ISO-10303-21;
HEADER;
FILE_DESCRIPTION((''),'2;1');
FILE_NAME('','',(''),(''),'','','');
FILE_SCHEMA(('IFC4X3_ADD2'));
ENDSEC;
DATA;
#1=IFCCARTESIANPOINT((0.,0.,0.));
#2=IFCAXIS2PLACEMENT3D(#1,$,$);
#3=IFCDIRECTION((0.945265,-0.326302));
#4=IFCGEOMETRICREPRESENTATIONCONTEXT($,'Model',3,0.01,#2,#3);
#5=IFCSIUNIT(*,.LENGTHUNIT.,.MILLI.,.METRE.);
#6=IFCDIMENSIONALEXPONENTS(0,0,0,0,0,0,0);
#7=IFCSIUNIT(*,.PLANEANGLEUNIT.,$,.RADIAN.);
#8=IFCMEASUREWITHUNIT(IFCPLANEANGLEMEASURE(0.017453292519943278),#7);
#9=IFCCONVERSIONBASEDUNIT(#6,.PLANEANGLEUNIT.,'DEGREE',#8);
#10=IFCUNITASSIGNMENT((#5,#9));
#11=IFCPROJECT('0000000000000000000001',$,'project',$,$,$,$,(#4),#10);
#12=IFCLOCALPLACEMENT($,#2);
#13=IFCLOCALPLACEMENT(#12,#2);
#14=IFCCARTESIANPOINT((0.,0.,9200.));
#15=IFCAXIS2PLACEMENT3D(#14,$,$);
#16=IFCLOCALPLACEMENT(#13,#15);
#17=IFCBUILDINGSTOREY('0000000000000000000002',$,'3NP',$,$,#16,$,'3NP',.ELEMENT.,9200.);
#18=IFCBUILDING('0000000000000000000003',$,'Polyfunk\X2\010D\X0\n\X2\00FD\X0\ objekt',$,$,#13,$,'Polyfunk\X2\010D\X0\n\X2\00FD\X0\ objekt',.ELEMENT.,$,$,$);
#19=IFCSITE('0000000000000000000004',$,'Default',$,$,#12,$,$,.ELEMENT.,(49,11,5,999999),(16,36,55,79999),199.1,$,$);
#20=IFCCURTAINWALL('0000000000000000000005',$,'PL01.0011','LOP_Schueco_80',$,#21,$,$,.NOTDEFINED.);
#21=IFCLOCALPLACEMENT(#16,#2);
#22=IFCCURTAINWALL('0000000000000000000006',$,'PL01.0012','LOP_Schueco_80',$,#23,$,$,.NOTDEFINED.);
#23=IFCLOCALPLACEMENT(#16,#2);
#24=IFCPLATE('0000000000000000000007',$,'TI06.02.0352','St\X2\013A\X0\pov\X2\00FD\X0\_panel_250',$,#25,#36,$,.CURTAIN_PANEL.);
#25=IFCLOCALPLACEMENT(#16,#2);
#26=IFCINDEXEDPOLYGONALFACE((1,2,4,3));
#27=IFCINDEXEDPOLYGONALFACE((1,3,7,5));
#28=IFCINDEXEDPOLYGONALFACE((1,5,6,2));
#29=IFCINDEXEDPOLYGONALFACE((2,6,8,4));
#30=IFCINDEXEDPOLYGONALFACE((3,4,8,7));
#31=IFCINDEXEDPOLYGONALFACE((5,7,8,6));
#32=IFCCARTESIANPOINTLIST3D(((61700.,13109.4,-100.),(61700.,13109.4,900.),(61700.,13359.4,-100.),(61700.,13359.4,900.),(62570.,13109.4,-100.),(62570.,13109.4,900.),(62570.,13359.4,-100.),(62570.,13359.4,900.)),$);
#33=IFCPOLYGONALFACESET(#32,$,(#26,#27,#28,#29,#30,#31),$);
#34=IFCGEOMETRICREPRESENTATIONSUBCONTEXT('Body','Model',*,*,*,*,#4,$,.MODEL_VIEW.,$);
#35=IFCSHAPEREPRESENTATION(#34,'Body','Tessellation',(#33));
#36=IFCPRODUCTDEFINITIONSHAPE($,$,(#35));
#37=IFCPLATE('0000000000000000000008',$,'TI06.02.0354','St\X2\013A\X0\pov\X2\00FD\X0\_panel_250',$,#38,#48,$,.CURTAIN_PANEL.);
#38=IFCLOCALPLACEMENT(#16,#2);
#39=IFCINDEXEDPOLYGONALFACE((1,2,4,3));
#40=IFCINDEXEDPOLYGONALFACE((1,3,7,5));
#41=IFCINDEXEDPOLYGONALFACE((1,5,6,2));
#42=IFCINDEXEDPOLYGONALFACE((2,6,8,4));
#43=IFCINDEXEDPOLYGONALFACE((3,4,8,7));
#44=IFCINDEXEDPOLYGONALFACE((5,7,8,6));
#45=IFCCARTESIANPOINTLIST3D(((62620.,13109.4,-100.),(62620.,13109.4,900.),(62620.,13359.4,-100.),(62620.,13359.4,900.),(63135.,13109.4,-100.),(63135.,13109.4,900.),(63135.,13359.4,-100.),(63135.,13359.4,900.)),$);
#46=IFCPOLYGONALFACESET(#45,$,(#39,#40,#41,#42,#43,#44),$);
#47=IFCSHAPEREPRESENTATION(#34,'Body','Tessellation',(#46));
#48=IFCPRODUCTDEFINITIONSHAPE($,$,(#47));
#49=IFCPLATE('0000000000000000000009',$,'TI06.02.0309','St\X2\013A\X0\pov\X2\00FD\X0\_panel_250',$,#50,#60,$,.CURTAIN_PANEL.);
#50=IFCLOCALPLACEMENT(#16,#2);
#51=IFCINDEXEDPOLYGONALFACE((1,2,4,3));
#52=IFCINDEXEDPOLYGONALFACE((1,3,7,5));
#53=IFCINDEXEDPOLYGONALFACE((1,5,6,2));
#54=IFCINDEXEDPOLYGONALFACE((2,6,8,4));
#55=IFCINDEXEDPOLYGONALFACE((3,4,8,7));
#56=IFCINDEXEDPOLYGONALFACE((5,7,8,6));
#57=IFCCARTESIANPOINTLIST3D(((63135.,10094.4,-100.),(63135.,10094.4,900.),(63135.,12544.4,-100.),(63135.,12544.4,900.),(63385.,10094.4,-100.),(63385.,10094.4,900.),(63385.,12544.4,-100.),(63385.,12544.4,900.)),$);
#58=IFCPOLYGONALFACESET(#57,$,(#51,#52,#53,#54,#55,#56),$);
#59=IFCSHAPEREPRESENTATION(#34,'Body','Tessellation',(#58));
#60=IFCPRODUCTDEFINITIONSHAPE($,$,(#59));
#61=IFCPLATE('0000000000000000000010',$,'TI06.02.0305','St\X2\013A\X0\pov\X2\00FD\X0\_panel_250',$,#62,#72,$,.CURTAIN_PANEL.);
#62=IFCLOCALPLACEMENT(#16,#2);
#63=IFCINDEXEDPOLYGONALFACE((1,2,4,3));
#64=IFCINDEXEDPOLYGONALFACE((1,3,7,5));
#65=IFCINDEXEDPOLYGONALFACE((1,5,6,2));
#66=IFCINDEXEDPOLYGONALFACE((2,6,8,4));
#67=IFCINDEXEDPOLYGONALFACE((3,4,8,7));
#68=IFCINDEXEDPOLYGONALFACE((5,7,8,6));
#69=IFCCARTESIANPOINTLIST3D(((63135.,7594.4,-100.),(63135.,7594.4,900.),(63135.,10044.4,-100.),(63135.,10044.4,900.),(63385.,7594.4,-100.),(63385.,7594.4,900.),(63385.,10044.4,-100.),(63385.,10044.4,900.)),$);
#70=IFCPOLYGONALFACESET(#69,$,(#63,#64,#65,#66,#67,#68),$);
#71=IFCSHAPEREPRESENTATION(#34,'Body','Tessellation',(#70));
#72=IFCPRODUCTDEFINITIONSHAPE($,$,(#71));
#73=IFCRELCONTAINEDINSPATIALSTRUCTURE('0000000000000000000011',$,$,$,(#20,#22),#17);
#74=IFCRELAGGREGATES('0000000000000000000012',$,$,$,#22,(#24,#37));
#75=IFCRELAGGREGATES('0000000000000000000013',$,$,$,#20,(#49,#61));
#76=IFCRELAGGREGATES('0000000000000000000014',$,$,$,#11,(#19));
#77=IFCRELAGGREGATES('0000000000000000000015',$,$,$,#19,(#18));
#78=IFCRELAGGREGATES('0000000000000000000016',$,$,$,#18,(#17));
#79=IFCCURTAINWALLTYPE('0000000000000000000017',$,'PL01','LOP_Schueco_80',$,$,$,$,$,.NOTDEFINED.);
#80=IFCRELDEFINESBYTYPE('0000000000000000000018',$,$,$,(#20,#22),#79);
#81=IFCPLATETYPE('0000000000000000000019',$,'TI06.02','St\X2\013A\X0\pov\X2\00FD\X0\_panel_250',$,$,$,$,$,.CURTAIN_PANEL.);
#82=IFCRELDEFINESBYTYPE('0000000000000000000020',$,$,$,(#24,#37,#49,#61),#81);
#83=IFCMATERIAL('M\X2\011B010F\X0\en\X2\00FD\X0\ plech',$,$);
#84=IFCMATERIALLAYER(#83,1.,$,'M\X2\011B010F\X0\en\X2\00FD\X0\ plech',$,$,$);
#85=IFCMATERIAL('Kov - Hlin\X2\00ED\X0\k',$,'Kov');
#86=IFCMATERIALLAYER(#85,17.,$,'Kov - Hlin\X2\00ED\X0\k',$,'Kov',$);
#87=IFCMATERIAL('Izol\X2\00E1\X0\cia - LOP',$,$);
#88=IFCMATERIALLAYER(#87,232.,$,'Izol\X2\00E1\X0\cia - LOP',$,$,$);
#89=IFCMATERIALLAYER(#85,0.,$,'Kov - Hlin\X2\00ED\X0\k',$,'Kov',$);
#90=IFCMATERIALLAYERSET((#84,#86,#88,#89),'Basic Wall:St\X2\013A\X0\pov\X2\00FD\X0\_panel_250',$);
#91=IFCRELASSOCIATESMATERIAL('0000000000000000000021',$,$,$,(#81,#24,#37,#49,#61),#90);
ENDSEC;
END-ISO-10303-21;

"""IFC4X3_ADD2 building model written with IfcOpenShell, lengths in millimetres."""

from ifc_helpers import new_model, entity, si_unit, converted_unit, direction, frame, frame_2d, origin, origin_2d_with_axis, place, context, subcontext, project, spatial, rectangle, extrude, material, layer, layer_set, layer_usage, type_object, element, aggregate, save


model = new_model("IFC4X3_ADD2")

# Units and contexts
model_context = context("Model", 3, precision=0.01, world=origin(), true_north=direction((0.945265, -0.326302)))
body_context = subcontext(model_context, "Body", "Model", "MODEL_VIEW")
ifc_project = project(units=[si_unit("LENGTHUNIT", "METRE", prefix="MILLI"), converted_unit("PLANEANGLEUNIT", "DEGREE", entity("IfcPlaneAngleMeasure", 0.017453292519943278), si_unit("PLANEANGLEUNIT", "RADIAN"), dimensions=[0, 0, 0, 0, 0, 0, 0])], contexts=[model_context])

# Site, building, storey
site_placement = place(None, origin())
site = spatial("IfcSite", under=ifc_project, at=site_placement, Name="Default", CompositionType="ELEMENT", RefLatitude=(49, 11, 5, 999999), RefLongitude=(16, 36, 55, 79999), RefElevation=199.1)
building_placement = place(site_placement, origin())
building = spatial("IfcBuilding", under=site, at=building_placement, Name="Polyfunkčný objekt", LongName="Polyfunkčný objekt", CompositionType="ELEMENT")
storey_placement = place(building_placement, frame((0.0, 0.0, 9200.0)))
storey = spatial("IfcBuildingStorey", under=building, at=storey_placement, Name="3NP", LongName="3NP", CompositionType="ELEMENT", Elevation=9200.0)

# Curtain wall
curtain_wall_type = type_object("IfcCurtainWallType", Name="PL01", Description="LOP_Schueco_80", PredefinedType="NOTDEFINED")
curtain_wall_1_placement = place(storey_placement, frame((0.0, 0.0, -9200.0)))
curtain_wall_1 = element("IfcCurtainWall", 1, at=curtain_wall_1_placement, inside=storey, type_object=curtain_wall_type, Name="PL01.0011", Description="LOP_Schueco_80", PredefinedType="NOTDEFINED")

# Curtain wall
curtain_wall_2_placement = place(storey_placement, frame((0.0, 0.0, -9200.0)))
curtain_wall_2 = element("IfcCurtainWall", 2, at=curtain_wall_2_placement, inside=storey, type_object=curtain_wall_type, Name="PL01.0012", Description="LOP_Schueco_80", PredefinedType="NOTDEFINED")

# Plates
ifc_material_1 = material(Name="Měďený plech")
ifc_layer_1 = layer(ifc_material_1, 1.0, Name="Měďený plech")
ifc_material_2 = material(Name="Kov - Hliník", Category="Kov")
ifc_layer_2 = layer(ifc_material_2, 17.0, Name="Kov - Hliník", Category="Kov")
ifc_material_3 = material(Name="Izolácia - LOP")
ifc_layer_3 = layer(ifc_material_3, 232.0, Name="Izolácia - LOP")
ifc_layer_4 = layer(ifc_material_2, 0.0, Name="Kov - Hliník", Category="Kov")
ifc_layer_set = layer_set([ifc_layer_1, ifc_layer_2, ifc_layer_3, ifc_layer_4], Name="Basic Wall:Stĺpový_panel_250")
ifc_layer_usage_1 = layer_usage(ifc_layer_set, "AXIS2", "NEGATIVE", 125.0)
plate_type = type_object("IfcPlateType", Name="TI06.02", Description="Stĺpový_panel_250", PredefinedType="CURTAIN_PANEL", material=ifc_layer_set)
plate_1_placement = place(storey_placement, frame((61700.0, 13234.4, -100.0)))
plate_1 = element("IfcPlate", 3, at=plate_1_placement, type_object=plate_type, material=ifc_layer_usage_1, Name="TI06.02.0352", Description="Stĺpový_panel_250", PredefinedType="CURTAIN_PANEL", context=body_context, shape_type="SweptSolid", body=[
    extrude(rectangle(XDim=250.0, YDim=870.0, at=frame_2d((0.0, 0.0), x_axis=(1.0, 0.0))), frame((435.0, 0.0, 0.0), z_axis=(0.0, 0.0, 1.0), x_axis=(0.0, 1.0, 0.0)), (0.0, 0.0, 1.0), 1000.0),
])
ifc_layer_usage_2 = layer_usage(ifc_layer_set, "AXIS2", "NEGATIVE", 125.0)
plate_2_placement = place(storey_placement, frame((62620.0, 13234.4, -100.0)))
plate_2 = element("IfcPlate", 4, at=plate_2_placement, type_object=plate_type, material=ifc_layer_usage_2, Name="TI06.02.0354", Description="Stĺpový_panel_250", PredefinedType="CURTAIN_PANEL", context=body_context, shape_type="SweptSolid", body=[
    extrude(rectangle(XDim=250.0, YDim=515.0, at=frame_2d((0.0, 0.0), x_axis=(1.0, 0.0))), frame((257.5, 0.0, 0.0), z_axis=(0.0, 0.0, 1.0), x_axis=(0.0, 1.0, 0.0)), (0.0, 0.0, 1.0), 1000.0),
])
aggregate(curtain_wall_2, [plate_1, plate_2])
ifc_layer_usage_3 = layer_usage(ifc_layer_set, "AXIS2", "NEGATIVE", 125.0)
plate_3_placement = place(storey_placement, frame((63260.0, 12544.4, -100.0), z_axis=(0.0, 0.0, 1.0), x_axis=(0.0, -1.0, 0.0)))
plate_3 = element("IfcPlate", 5, at=plate_3_placement, type_object=plate_type, material=ifc_layer_usage_3, Name="TI06.02.0309", Description="Stĺpový_panel_250", PredefinedType="CURTAIN_PANEL", context=body_context, shape_type="SweptSolid", body=[
    extrude(rectangle(XDim=250.0, YDim=2450.0, at=frame_2d((0.0, 0.0), x_axis=(1.0, 0.0))), frame((1225.0, 0.0, 0.0), z_axis=(0.0, 0.0, 1.0), x_axis=(0.0, 1.0, 0.0)), (0.0, 0.0, 1.0), 1000.0),
])
ifc_layer_usage_4 = layer_usage(ifc_layer_set, "AXIS2", "NEGATIVE", 125.0)
plate_4_placement = place(storey_placement, frame((63260.0, 10044.4, -100.0), z_axis=(0.0, 0.0, 1.0), x_axis=(0.0, -1.0, 0.0)))
plate_4 = element("IfcPlate", 6, at=plate_4_placement, type_object=plate_type, material=ifc_layer_usage_4, Name="TI06.02.0305", Description="Stĺpový_panel_250", PredefinedType="CURTAIN_PANEL", context=body_context, shape_type="SweptSolid", body=[
    extrude(rectangle(XDim=250.0, YDim=2450.0, at=origin_2d_with_axis()), frame((1225.0, 0.0, 0.0), z_axis=(0.0, 0.0, 1.0), x_axis=(0.0, 1.0, 0.0)), (0.0, 0.0, 1.0), 1000.0),
])
aggregate(curtain_wall_1, [plate_3, plate_4])

save(model, "model.ifc")
